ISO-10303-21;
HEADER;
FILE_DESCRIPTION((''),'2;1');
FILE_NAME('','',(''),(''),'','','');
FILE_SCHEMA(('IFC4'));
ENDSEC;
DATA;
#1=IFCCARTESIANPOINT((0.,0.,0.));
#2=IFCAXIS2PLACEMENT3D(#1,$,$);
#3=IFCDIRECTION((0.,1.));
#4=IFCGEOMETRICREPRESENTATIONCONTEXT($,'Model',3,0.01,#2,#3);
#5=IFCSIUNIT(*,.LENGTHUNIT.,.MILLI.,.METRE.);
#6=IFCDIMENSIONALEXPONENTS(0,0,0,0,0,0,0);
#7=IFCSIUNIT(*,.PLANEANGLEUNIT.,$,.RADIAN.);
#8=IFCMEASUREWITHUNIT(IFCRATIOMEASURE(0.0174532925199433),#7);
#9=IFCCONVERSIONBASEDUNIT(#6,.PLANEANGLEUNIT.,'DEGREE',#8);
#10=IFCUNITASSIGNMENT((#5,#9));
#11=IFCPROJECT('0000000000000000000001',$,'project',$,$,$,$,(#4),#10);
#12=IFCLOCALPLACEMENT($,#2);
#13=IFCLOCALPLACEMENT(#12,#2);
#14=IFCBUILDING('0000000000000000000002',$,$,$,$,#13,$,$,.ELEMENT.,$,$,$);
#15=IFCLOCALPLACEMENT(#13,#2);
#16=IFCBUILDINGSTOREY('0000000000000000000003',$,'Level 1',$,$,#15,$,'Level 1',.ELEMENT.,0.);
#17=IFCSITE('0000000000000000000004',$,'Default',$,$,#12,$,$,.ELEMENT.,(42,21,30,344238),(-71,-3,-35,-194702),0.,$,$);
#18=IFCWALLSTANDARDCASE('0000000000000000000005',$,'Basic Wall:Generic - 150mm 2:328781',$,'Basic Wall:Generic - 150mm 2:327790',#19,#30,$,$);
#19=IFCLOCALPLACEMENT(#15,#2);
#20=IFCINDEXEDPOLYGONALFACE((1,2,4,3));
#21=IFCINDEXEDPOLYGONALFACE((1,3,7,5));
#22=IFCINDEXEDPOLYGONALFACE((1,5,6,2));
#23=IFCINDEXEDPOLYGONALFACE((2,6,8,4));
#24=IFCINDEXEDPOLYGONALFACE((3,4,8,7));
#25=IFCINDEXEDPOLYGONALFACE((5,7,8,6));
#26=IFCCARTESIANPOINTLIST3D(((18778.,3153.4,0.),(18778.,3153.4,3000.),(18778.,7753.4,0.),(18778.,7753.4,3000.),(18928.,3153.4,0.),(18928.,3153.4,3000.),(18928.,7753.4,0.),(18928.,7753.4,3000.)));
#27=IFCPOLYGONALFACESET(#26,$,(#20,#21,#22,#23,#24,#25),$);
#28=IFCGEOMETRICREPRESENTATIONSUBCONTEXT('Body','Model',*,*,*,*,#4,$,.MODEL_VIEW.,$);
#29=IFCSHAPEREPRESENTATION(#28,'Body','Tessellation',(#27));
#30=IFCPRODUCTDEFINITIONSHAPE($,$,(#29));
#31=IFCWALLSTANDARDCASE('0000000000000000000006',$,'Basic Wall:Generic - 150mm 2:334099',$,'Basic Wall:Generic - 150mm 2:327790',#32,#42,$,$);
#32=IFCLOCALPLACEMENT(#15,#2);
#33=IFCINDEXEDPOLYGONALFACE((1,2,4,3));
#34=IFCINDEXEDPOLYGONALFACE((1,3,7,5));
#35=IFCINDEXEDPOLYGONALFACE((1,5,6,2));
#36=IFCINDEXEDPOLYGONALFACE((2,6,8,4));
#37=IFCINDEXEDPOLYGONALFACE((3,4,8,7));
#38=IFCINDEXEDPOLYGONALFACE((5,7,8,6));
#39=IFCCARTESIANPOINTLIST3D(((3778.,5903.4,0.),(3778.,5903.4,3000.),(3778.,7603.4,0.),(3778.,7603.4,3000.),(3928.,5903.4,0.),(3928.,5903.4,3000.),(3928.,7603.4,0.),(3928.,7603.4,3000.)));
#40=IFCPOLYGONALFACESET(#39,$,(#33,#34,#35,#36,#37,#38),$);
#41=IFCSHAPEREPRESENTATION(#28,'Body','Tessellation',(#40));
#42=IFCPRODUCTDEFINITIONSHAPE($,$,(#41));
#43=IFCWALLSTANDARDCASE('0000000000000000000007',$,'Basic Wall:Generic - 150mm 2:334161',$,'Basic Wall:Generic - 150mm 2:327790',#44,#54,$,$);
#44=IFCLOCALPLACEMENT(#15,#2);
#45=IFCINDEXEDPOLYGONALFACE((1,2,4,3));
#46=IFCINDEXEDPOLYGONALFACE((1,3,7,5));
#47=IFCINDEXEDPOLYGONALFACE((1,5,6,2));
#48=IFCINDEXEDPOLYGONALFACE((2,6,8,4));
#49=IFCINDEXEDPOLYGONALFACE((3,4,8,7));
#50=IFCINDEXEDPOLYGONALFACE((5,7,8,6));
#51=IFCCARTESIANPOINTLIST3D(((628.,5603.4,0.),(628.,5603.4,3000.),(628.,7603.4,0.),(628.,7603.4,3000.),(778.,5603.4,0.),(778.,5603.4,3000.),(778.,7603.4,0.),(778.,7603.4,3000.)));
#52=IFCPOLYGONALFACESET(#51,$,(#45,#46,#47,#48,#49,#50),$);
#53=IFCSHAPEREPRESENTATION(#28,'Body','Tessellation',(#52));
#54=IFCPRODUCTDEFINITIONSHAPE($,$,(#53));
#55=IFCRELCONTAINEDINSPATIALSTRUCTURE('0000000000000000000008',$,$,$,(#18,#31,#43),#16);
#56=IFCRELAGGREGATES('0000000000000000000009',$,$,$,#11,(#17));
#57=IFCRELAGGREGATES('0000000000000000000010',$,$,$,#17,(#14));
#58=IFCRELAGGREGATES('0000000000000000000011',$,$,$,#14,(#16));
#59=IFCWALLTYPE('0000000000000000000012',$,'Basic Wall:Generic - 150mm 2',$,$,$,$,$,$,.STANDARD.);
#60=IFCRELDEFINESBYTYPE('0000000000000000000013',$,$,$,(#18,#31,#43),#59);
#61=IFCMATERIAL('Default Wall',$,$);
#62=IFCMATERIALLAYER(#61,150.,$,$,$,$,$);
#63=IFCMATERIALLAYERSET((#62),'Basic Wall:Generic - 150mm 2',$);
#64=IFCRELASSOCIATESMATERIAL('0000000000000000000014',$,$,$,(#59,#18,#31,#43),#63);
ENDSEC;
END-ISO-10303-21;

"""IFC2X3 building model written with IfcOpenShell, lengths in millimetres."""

from ifc_helpers import new_model, entity, si_unit, converted_unit, direction, frame, frame_2d, origin, place, context, subcontext, project, spatial, rectangle, extrude, material, layer, layer_set, layer_usage, type_object, element, save


model = new_model("IFC2X3")

# Units and contexts
model_context = context("Model", 3, precision=0.01, world=origin(), true_north=direction((0.0, 1.0)))
body_context = subcontext(model_context, "Body", "Model", "MODEL_VIEW")
ifc_project = project(units=[si_unit("LENGTHUNIT", "METRE", prefix="MILLI"), converted_unit("PLANEANGLEUNIT", "DEGREE", entity("IfcRatioMeasure", 0.0174532925199433), si_unit("PLANEANGLEUNIT", "RADIAN"), dimensions=[0, 0, 0, 0, 0, 0, 0])], contexts=[model_context])

# Site, building, storey
site_placement = place(None, origin())
site = spatial("IfcSite", under=ifc_project, at=site_placement, Name="Default", CompositionType="ELEMENT", RefLatitude=(42, 21, 30, 344238), RefLongitude=(-71, -3, -35, -194702), RefElevation=0.0)
building_placement = place(site_placement, origin())
building = spatial("IfcBuilding", under=site, at=building_placement, CompositionType="ELEMENT")
storey_placement = place(building_placement, origin())
storey = spatial("IfcBuildingStorey", under=building, at=storey_placement, Name="Level 1", LongName="Level 1", CompositionType="ELEMENT", Elevation=0.0)

# Shared definitions
ifc_material_1 = material(Name="Default Wall")
ifc_layer = layer(ifc_material_1, 150.0)
ifc_layer_set = layer_set([ifc_layer], Name="Basic Wall:Generic - 150mm 2")
wall_type = type_object("IfcWallType", Name="Basic Wall:Generic - 150mm 2", PredefinedType="STANDARD", material=ifc_layer_set)

# Walls
ifc_layer_usage_1 = layer_usage(ifc_layer_set, "AXIS2", "NEGATIVE", 75.0)
wall_1_placement = place(storey_placement, frame((18853.0, 7753.4, 0.0), z_axis=(0.0, 0.0, 1.0), x_axis=(0.0, -1.0, 0.0)))
element("IfcWallStandardCase", 1, at=wall_1_placement, inside=storey, type_object=wall_type, material=ifc_layer_usage_1, Name="Basic Wall:Generic - 150mm 2:328781", ObjectType="Basic Wall:Generic - 150mm 2:327790", context=body_context, shape_type="SweptSolid", body=[
    extrude(rectangle(XDim=4600.0, YDim=150.0, at=frame_2d((2300.0, 0.0), x_axis=(-1.0, 0.0))), origin(), (0.0, 0.0, 1.0), 3000.0),
])
ifc_layer_usage_2 = layer_usage(ifc_layer_set, "AXIS2", "NEGATIVE", 75.0)
wall_2_placement = place(storey_placement, frame((3853.0, 5903.4, 0.0), z_axis=(0.0, 0.0, 1.0), x_axis=(0.0, 1.0, 0.0)))
element("IfcWallStandardCase", 2, at=wall_2_placement, inside=storey, type_object=wall_type, material=ifc_layer_usage_2, Name="Basic Wall:Generic - 150mm 2:334099", ObjectType="Basic Wall:Generic - 150mm 2:327790", context=body_context, shape_type="SweptSolid", body=[
    extrude(rectangle(XDim=1700.0, YDim=150.0, at=frame_2d((850.0, 0.0), x_axis=(-1.0, 0.0))), origin(), (0.0, 0.0, 1.0), 3000.0),
])
ifc_layer_usage_3 = layer_usage(ifc_layer_set, "AXIS2", "NEGATIVE", 75.0)
wall_3_placement = place(storey_placement, frame((703.0, 7603.4, 0.0), z_axis=(0.0, 0.0, 1.0), x_axis=(0.0, -1.0, 0.0)))
element("IfcWallStandardCase", 3, at=wall_3_placement, inside=storey, type_object=wall_type, material=ifc_layer_usage_3, Name="Basic Wall:Generic - 150mm 2:334161", ObjectType="Basic Wall:Generic - 150mm 2:327790", context=body_context, shape_type="SweptSolid", body=[
    extrude(rectangle(XDim=2000.0, YDim=150.0, at=frame_2d((1000.0, 0.0), x_axis=(-1.0, 0.0))), origin(), (0.0, 0.0, 1.0), 3000.0),
])

save(model, "model.ifc")
